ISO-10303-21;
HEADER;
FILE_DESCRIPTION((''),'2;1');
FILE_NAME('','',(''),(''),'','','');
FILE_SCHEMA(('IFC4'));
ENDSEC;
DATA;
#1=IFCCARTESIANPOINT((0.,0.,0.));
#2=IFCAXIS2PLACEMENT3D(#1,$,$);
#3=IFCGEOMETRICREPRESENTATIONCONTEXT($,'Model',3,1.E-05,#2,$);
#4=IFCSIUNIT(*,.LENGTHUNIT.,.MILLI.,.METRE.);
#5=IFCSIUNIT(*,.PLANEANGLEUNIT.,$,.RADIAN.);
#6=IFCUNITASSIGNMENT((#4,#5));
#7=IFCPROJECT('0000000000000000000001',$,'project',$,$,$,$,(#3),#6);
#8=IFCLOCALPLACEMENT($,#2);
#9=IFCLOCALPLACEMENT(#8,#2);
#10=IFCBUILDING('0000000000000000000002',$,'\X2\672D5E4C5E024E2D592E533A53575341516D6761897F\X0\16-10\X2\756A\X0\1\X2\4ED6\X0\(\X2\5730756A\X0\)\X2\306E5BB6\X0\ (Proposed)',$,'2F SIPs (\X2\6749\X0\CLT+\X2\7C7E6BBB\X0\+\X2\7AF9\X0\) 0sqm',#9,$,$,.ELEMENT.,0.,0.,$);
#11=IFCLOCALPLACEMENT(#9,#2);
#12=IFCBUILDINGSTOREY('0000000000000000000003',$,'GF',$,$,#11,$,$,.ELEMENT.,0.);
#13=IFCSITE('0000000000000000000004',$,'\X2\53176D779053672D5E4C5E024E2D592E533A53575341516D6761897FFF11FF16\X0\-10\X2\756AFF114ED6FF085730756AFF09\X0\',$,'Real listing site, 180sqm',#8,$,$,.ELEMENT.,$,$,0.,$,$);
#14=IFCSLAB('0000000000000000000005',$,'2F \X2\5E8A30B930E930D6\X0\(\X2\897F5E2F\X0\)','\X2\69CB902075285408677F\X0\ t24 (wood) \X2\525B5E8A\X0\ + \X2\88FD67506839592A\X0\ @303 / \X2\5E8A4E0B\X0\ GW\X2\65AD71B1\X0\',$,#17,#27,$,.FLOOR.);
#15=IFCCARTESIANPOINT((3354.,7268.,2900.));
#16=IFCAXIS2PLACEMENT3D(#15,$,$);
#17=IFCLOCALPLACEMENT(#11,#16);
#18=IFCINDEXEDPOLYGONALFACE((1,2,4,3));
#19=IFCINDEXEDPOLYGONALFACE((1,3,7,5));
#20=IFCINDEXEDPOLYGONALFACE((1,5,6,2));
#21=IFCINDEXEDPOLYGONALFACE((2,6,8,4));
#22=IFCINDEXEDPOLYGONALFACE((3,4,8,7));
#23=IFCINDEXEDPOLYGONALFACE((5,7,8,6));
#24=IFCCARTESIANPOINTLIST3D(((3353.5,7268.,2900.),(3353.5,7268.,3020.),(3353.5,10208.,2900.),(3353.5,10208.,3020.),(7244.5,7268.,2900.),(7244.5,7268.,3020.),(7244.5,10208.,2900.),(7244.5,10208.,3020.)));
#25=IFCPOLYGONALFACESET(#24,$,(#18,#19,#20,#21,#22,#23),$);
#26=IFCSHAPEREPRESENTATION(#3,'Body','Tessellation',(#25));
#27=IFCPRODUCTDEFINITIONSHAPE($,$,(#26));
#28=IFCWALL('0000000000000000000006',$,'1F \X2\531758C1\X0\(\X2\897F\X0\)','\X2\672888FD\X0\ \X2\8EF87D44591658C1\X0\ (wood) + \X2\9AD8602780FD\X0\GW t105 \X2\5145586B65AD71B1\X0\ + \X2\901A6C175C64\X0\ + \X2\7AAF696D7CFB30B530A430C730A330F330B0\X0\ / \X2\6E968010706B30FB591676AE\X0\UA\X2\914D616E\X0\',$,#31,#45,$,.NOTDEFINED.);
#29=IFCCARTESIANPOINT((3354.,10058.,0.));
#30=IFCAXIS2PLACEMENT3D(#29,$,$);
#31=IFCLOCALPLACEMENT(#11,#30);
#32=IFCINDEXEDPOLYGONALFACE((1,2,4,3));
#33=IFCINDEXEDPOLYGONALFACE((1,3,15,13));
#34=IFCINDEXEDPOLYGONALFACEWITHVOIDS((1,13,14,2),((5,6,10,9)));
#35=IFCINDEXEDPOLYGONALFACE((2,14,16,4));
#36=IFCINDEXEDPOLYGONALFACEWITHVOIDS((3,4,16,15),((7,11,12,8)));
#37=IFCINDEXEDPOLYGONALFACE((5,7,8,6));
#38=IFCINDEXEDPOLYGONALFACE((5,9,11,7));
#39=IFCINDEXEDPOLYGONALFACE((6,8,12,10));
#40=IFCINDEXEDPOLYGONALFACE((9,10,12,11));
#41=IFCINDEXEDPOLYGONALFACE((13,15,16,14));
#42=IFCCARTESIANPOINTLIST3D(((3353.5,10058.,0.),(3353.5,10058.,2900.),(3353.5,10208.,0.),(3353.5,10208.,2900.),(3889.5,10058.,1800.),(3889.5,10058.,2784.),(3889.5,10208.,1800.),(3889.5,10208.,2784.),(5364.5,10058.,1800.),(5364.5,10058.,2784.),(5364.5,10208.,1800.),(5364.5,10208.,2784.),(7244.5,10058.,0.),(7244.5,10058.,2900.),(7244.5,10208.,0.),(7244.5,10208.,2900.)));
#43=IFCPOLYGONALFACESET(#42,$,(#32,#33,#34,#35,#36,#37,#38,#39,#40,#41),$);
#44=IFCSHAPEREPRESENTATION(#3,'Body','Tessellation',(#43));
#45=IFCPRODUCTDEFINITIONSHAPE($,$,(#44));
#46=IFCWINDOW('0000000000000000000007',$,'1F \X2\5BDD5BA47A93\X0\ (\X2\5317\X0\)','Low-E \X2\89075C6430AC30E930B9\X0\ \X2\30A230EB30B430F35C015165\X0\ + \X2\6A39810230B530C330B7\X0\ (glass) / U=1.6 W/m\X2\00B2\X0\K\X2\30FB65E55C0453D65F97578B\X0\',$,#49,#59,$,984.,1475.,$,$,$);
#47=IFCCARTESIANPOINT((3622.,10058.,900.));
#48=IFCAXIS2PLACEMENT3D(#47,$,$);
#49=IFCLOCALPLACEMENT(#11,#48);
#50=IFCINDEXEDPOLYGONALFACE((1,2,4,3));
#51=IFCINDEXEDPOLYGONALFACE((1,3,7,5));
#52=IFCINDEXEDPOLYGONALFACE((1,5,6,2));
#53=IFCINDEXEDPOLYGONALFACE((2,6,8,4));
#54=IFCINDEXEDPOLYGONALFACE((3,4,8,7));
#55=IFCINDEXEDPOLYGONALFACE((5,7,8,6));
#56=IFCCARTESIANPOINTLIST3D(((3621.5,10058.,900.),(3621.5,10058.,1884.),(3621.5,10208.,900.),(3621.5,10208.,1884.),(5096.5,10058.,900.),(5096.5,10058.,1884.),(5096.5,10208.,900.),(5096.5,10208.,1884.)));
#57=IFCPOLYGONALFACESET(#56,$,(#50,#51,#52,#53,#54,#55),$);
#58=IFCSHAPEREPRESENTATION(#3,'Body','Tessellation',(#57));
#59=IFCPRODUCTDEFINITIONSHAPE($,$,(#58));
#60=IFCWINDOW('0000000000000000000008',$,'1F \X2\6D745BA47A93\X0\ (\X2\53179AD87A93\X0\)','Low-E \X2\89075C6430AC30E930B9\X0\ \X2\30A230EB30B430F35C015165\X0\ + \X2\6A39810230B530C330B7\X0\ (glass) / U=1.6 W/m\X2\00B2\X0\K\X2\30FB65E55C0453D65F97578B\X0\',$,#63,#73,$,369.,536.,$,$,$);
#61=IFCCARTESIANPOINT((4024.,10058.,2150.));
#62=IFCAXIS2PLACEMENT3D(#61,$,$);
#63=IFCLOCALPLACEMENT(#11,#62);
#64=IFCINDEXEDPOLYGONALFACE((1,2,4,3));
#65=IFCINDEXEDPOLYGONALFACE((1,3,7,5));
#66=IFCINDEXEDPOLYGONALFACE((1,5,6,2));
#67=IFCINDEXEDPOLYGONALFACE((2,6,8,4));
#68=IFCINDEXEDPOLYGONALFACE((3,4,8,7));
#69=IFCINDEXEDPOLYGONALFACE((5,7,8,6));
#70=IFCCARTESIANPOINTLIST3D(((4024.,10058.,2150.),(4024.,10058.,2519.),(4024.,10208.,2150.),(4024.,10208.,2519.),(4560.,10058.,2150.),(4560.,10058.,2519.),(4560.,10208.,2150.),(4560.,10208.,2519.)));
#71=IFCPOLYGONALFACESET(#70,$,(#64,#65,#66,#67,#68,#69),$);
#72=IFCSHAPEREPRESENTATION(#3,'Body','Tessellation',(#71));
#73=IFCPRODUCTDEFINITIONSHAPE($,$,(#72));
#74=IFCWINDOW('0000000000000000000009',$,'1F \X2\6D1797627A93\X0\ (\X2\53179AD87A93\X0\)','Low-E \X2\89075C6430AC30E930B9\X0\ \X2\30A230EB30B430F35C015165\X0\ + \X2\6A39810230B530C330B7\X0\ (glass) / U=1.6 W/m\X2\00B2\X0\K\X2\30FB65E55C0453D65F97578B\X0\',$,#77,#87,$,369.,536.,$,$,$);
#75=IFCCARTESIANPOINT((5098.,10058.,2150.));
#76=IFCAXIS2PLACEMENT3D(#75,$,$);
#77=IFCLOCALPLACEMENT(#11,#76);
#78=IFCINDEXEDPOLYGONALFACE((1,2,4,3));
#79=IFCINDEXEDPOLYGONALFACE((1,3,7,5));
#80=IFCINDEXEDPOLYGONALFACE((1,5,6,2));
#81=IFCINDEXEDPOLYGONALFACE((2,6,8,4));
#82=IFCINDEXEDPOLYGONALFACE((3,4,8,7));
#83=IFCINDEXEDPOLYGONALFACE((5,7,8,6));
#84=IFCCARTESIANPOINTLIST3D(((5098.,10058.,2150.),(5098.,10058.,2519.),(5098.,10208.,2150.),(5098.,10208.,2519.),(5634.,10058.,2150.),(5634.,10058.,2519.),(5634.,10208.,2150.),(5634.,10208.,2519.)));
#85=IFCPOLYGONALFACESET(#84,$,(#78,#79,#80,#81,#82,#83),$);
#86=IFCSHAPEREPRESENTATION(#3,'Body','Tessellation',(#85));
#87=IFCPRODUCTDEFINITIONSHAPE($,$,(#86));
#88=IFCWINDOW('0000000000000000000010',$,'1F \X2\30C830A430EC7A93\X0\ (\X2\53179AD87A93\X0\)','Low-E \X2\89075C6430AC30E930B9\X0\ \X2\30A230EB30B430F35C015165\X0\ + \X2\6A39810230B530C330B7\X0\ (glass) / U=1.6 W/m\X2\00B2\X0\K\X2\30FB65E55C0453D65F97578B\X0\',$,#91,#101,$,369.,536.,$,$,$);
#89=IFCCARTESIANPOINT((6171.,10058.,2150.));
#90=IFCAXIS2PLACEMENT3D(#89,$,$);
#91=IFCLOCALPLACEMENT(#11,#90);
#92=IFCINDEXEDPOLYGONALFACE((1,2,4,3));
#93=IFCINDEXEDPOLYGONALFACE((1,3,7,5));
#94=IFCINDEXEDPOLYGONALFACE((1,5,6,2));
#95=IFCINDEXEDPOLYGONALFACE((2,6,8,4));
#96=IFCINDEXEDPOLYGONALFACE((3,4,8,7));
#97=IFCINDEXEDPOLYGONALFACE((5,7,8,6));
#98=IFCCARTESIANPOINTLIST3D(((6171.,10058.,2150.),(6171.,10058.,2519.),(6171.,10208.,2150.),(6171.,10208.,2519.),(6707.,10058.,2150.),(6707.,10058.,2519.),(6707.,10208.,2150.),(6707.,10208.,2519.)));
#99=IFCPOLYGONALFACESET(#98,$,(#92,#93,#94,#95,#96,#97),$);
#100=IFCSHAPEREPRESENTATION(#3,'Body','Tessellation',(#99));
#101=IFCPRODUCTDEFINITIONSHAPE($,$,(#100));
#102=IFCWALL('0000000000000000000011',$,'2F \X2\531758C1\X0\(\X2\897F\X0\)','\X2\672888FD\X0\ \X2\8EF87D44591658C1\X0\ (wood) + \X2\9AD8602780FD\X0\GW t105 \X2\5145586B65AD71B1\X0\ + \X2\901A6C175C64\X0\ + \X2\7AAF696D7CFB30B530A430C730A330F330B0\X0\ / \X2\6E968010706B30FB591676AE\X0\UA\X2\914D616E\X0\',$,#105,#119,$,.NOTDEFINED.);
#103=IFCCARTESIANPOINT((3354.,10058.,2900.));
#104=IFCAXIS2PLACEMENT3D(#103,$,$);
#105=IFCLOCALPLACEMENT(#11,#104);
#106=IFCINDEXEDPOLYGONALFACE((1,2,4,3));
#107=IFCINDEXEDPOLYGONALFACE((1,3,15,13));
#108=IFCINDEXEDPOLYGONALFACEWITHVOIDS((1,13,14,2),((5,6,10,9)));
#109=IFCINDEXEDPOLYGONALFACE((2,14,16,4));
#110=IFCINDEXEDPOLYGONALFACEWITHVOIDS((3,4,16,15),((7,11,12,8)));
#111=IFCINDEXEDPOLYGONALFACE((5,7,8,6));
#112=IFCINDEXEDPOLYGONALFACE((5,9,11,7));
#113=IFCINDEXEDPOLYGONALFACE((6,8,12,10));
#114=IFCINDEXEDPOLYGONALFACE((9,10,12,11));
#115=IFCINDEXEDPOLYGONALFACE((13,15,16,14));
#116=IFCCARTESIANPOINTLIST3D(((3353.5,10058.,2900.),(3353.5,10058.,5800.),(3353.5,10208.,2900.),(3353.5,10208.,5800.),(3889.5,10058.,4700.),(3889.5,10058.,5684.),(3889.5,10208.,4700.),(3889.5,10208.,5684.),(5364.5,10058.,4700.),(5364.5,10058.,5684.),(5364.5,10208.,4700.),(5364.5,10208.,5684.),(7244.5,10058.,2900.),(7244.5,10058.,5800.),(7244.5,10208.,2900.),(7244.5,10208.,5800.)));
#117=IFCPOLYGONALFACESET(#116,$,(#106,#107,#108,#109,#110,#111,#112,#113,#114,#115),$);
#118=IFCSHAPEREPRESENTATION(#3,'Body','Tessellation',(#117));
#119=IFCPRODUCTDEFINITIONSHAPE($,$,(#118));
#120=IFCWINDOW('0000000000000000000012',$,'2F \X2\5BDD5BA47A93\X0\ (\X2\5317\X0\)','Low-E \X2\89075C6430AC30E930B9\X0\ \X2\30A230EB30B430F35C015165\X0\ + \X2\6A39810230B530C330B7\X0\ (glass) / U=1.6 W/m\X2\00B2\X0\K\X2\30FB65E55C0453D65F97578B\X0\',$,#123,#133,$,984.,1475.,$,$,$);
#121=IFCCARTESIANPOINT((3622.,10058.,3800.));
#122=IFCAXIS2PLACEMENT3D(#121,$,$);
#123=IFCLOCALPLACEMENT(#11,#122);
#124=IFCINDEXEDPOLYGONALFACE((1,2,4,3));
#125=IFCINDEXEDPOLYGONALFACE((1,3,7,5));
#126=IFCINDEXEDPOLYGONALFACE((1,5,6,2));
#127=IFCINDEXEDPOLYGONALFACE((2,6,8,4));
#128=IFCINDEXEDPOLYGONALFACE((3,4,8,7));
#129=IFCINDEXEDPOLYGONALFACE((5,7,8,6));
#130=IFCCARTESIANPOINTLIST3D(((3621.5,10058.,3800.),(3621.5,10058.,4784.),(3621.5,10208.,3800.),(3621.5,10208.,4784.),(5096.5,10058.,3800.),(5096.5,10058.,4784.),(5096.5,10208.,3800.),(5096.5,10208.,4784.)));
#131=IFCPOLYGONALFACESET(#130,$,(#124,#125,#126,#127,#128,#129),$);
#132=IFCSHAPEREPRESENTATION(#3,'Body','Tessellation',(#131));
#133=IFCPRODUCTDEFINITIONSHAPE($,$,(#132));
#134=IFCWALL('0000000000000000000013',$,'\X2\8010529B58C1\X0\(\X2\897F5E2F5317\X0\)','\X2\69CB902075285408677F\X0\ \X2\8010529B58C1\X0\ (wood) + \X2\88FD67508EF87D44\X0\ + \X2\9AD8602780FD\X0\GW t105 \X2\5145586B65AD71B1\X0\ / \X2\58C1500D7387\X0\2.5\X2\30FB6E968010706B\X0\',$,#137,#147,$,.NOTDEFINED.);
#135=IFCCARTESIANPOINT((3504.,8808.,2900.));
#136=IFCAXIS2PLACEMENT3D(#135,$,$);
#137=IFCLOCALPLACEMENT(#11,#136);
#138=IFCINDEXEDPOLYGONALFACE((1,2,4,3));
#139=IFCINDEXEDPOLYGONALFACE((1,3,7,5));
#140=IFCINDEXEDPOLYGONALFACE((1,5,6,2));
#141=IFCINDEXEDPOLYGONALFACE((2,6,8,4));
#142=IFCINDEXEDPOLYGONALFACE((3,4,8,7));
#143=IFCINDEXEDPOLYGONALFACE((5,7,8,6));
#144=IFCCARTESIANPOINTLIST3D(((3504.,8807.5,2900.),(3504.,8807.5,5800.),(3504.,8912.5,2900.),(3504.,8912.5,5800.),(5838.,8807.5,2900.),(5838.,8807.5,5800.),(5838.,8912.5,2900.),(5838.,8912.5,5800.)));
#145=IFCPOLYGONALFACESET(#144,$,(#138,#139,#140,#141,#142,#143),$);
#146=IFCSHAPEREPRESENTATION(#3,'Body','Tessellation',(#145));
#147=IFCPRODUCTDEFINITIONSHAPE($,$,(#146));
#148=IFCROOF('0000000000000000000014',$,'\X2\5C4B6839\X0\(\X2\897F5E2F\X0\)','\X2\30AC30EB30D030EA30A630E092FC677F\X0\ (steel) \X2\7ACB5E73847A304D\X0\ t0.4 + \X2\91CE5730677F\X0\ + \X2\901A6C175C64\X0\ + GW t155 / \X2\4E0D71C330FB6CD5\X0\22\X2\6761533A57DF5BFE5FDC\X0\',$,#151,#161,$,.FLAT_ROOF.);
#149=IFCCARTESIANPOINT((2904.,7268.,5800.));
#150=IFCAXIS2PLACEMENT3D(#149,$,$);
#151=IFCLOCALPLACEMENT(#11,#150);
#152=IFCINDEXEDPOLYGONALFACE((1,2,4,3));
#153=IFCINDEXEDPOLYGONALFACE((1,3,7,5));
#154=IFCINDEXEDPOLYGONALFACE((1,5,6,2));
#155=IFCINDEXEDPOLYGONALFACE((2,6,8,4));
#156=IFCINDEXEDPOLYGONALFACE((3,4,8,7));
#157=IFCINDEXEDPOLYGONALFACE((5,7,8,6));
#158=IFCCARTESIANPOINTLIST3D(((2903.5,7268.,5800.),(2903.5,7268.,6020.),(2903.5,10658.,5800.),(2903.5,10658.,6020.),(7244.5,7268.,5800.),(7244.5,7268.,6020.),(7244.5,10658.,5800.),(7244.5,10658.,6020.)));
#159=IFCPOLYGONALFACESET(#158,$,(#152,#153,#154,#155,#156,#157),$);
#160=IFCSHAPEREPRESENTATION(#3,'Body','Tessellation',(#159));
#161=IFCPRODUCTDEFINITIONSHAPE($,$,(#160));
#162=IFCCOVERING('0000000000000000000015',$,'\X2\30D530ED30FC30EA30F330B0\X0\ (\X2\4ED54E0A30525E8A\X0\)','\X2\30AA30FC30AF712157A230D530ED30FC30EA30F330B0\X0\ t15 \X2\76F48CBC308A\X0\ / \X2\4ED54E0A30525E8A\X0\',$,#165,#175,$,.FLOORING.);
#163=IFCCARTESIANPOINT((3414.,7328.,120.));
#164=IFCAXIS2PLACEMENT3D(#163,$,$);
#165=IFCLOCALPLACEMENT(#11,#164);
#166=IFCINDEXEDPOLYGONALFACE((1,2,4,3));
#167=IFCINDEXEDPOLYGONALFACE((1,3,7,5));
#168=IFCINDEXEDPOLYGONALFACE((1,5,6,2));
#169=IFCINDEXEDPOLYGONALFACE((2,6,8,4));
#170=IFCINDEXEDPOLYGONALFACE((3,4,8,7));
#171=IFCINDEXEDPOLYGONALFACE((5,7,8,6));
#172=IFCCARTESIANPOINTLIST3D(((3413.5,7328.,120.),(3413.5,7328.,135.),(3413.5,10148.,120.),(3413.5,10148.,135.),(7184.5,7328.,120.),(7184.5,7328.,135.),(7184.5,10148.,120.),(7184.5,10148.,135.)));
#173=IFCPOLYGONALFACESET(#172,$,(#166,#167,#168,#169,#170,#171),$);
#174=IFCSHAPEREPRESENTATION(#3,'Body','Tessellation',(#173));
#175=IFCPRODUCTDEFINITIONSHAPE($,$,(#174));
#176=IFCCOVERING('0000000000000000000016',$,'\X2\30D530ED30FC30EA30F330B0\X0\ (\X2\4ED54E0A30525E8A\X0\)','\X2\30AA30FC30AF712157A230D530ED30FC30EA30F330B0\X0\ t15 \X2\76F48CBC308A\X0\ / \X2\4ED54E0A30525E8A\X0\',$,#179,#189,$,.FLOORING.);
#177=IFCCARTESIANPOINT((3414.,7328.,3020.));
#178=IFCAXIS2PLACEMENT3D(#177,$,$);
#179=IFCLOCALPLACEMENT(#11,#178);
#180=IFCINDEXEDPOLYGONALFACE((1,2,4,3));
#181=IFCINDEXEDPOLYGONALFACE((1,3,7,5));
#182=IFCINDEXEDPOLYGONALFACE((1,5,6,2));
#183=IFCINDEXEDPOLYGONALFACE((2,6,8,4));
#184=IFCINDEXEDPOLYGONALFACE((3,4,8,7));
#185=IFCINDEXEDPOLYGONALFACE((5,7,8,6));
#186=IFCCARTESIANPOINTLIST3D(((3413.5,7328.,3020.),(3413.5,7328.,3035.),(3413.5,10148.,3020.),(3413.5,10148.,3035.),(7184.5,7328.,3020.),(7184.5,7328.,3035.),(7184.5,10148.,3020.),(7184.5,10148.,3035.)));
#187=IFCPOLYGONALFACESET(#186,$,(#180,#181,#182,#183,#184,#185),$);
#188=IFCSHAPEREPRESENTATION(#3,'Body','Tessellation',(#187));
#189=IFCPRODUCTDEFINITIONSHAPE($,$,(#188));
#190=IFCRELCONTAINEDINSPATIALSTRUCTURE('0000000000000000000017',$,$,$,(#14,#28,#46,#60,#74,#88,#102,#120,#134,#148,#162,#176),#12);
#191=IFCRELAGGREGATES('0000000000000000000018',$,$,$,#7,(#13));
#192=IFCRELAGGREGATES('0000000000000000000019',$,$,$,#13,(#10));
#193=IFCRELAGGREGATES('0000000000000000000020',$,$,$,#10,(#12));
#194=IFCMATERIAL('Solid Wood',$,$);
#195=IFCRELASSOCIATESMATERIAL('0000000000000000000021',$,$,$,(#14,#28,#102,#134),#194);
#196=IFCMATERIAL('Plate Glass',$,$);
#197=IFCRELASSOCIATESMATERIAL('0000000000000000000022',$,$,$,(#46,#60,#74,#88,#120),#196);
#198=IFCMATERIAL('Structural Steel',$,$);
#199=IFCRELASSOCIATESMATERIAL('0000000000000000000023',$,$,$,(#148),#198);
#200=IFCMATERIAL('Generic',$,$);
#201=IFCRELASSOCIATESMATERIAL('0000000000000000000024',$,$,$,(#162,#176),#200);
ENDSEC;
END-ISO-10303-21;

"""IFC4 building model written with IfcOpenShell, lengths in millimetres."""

from ifc_helpers import new_model, si_unit, frame, frame_2d, origin, place, context, project, spatial, rectangle, extrude, material, element, fill, save


model = new_model("IFC4")

# Units and contexts
model_context = context("Model", 3, precision=1e-05, world=origin())
ifc_project = project(units=[si_unit("LENGTHUNIT", "METRE", prefix="MILLI"), si_unit("PLANEANGLEUNIT", "RADIAN")], contexts=[model_context])

# Site, building, storey
site_placement = place(None, origin())
site = spatial("IfcSite", under=ifc_project, at=site_placement, Name="北海道札幌市中央区南十六条西１６-10番１他（地番）", ObjectType="Real listing site, 180sqm", CompositionType="ELEMENT", RefElevation=0.0)
building_placement = place(site_placement, origin())
building = spatial("IfcBuilding", under=site, at=building_placement, Name="札幌市中央区南十六条西16-10番1他(地番)の家 (Proposed)", ObjectType="2F SIPs (杉CLT+籾殻+竹) 0sqm", CompositionType="ELEMENT", ElevationOfRefHeight=0.0, ElevationOfTerrain=0.0)
storey_placement = place(building_placement, origin())
storey = spatial("IfcBuildingStorey", under=building, at=storey_placement, Name="GF", CompositionType="ELEMENT", Elevation=0.0)

# Slab
ifc_material_1 = material(Name="Solid Wood")
slab_1_placement = place(storey_placement, frame((3354.0, 7268.0, 2900.0)))
element("IfcSlab", 1, at=slab_1_placement, inside=storey, material=ifc_material_1, Name="2F 床スラブ(西帯)", Description="構造用合板 t24 (wood) 剛床 + 製材根太 @303 / 床下 GW断熱", PredefinedType="FLOOR", context=model_context, shape_type="SweptSolid", body=[
    extrude(rectangle(XDim=3891.0, YDim=2940.0, at=frame_2d((1945.0, 1470.0))), frame((3354.0, 7268.0, 2900.0)), (0.0, 0.0, 1.0), 120.0),
])

# Wall, openings, windows
wall_1_placement = place(storey_placement, frame((3354.0, 10058.0, 0.0)))
wall_1 = element("IfcWall", 2, at=wall_1_placement, inside=storey, material=ifc_material_1, Name="1F 北壁(西)", Description="木製 軸組外壁 (wood) + 高性能GW t105 充填断熱 + 通気層 + 窯業系サイディング / 準耐火・外皮UA配慮", PredefinedType="NOTDEFINED", context=model_context, shape_type="SweptSolid", body=[
    extrude(rectangle(XDim=3891.0, YDim=150.0, at=frame_2d((1945.0, 75.0))), frame((3354.0, 10058.0, 0.0)), (0.0, 0.0, 1.0), 2900.0),
])
opening_1_placement = place(storey_placement, frame((3622.0, 10058.0, 900.0)))
opening_1 = element("IfcOpeningElement", 3, at=opening_1_placement, cuts=wall_1, PredefinedType="NOTDEFINED", context=model_context, shape_type="SweptSolid", body=[
    extrude(rectangle(XDim=1475.0, YDim=150.0, at=frame_2d((737.0, 75.0))), frame((3622.0, 10058.0, 900.0)), (0.0, 0.0, 1.0), 984.0),
])
opening_2_placement = place(storey_placement, frame((4024.0, 10058.0, 2150.0)))
opening_2 = element("IfcOpeningElement", 4, at=opening_2_placement, cuts=wall_1, PredefinedType="NOTDEFINED", context=model_context, shape_type="SweptSolid", body=[
    extrude(rectangle(XDim=536.0, YDim=150.0, at=frame_2d((268.0, 75.0))), frame((4024.0, 10058.0, 2150.0)), (0.0, 0.0, 1.0), 369.0),
])
opening_3_placement = place(storey_placement, frame((5098.0, 10058.0, 2150.0)))
opening_3 = element("IfcOpeningElement", 5, at=opening_3_placement, cuts=wall_1, PredefinedType="NOTDEFINED", context=model_context, shape_type="SweptSolid", body=[
    extrude(rectangle(XDim=536.0, YDim=150.0, at=frame_2d((268.0, 75.0))), frame((5098.0, 10058.0, 2150.0)), (0.0, 0.0, 1.0), 369.0),
])
opening_4_placement = place(storey_placement, frame((6171.0, 10058.0, 2150.0)))
opening_4 = element("IfcOpeningElement", 6, at=opening_4_placement, cuts=wall_1, PredefinedType="NOTDEFINED", context=model_context, shape_type="SweptSolid", body=[
    extrude(rectangle(XDim=536.0, YDim=150.0, at=frame_2d((268.0, 75.0))), frame((6171.0, 10058.0, 2150.0)), (0.0, 0.0, 1.0), 369.0),
])
ifc_material_2 = material(Name="Plate Glass")
window_1_placement = place(storey_placement, frame((3622.0, 10058.0, 900.0)))
window_1 = element("IfcWindow", 7, at=window_1_placement, inside=storey, material=ifc_material_2, Name="1F 寝室窓 (北)", Description="Low-E 複層ガラス アルゴン封入 + 樹脂サッシ (glass) / U=1.6 W/m²K・日射取得型", OverallHeight=984.0, OverallWidth=1475.0, context=model_context, shape_type="SweptSolid", body=[
    extrude(rectangle(XDim=1475.0, YDim=150.0, at=frame_2d((737.0, 75.0))), frame((3622.0, 10058.0, 900.0)), (0.0, 0.0, 1.0), 984.0),
])
fill(opening_1, window_1)
window_2_placement = place(storey_placement, frame((4024.0, 10058.0, 2150.0)))
window_2 = element("IfcWindow", 8, at=window_2_placement, inside=storey, material=ifc_material_2, Name="1F 浴室窓 (北高窓)", Description="Low-E 複層ガラス アルゴン封入 + 樹脂サッシ (glass) / U=1.6 W/m²K・日射取得型", OverallHeight=369.0, OverallWidth=536.0, context=model_context, shape_type="SweptSolid", body=[
    extrude(rectangle(XDim=536.0, YDim=150.0, at=frame_2d((268.0, 75.0))), frame((4024.0, 10058.0, 2150.0)), (0.0, 0.0, 1.0), 369.0),
])
fill(opening_2, window_2)
window_3_placement = place(storey_placement, frame((5098.0, 10058.0, 2150.0)))
window_3 = element("IfcWindow", 9, at=window_3_placement, inside=storey, material=ifc_material_2, Name="1F 洗面窓 (北高窓)", Description="Low-E 複層ガラス アルゴン封入 + 樹脂サッシ (glass) / U=1.6 W/m²K・日射取得型", OverallHeight=369.0, OverallWidth=536.0, context=model_context, shape_type="SweptSolid", body=[
    extrude(rectangle(XDim=536.0, YDim=150.0, at=frame_2d((268.0, 75.0))), frame((5098.0, 10058.0, 2150.0)), (0.0, 0.0, 1.0), 369.0),
])
fill(opening_3, window_3)
window_4_placement = place(storey_placement, frame((6171.0, 10058.0, 2150.0)))
window_4 = element("IfcWindow", 10, at=window_4_placement, inside=storey, material=ifc_material_2, Name="1F トイレ窓 (北高窓)", Description="Low-E 複層ガラス アルゴン封入 + 樹脂サッシ (glass) / U=1.6 W/m²K・日射取得型", OverallHeight=369.0, OverallWidth=536.0, context=model_context, shape_type="SweptSolid", body=[
    extrude(rectangle(XDim=536.0, YDim=150.0, at=frame_2d((268.0, 75.0))), frame((6171.0, 10058.0, 2150.0)), (0.0, 0.0, 1.0), 369.0),
])
fill(opening_4, window_4)

# Wall, opening, window
wall_2_placement = place(storey_placement, frame((3354.0, 10058.0, 2900.0)))
wall_2 = element("IfcWall", 11, at=wall_2_placement, inside=storey, material=ifc_material_1, Name="2F 北壁(西)", Description="木製 軸組外壁 (wood) + 高性能GW t105 充填断熱 + 通気層 + 窯業系サイディング / 準耐火・外皮UA配慮", PredefinedType="NOTDEFINED", context=model_context, shape_type="SweptSolid", body=[
    extrude(rectangle(XDim=3891.0, YDim=150.0, at=frame_2d((1945.0, 75.0))), frame((3354.0, 10058.0, 2900.0)), (0.0, 0.0, 1.0), 2900.0),
])
opening_5_placement = place(storey_placement, frame((3622.0, 10058.0, 3800.0)))
opening_5 = element("IfcOpeningElement", 12, at=opening_5_placement, cuts=wall_2, PredefinedType="NOTDEFINED", context=model_context, shape_type="SweptSolid", body=[
    extrude(rectangle(XDim=1475.0, YDim=150.0, at=frame_2d((737.0, 75.0))), frame((3622.0, 10058.0, 3800.0)), (0.0, 0.0, 1.0), 984.0),
])
window_5_placement = place(storey_placement, frame((3622.0, 10058.0, 3800.0)))
window_5 = element("IfcWindow", 13, at=window_5_placement, inside=storey, material=ifc_material_2, Name="2F 寝室窓 (北)", Description="Low-E 複層ガラス アルゴン封入 + 樹脂サッシ (glass) / U=1.6 W/m²K・日射取得型", OverallHeight=984.0, OverallWidth=1475.0, context=model_context, shape_type="SweptSolid", body=[
    extrude(rectangle(XDim=1475.0, YDim=150.0, at=frame_2d((737.0, 75.0))), frame((3622.0, 10058.0, 3800.0)), (0.0, 0.0, 1.0), 984.0),
])
fill(opening_5, window_5)

# Wall
wall_3_placement = place(storey_placement, frame((3504.0, 8808.0, 2900.0)))
element("IfcWall", 14, at=wall_3_placement, inside=storey, material=ifc_material_1, Name="耐力壁(西帯北)", Description="構造用合板 耐力壁 (wood) + 製材軸組 + 高性能GW t105 充填断熱 / 壁倍率2.5・準耐火", PredefinedType="NOTDEFINED", context=model_context, shape_type="SweptSolid", body=[
    extrude(rectangle(XDim=2334.0, YDim=105.0, at=frame_2d((1167.0, 52.0))), frame((3504.0, 8808.0, 2900.0)), (0.0, 0.0, 1.0), 2900.0),
])

# Roof
ifc_material_3 = material(Name="Structural Steel")
for number, where, name in (
    (15, (2904.0, 7268.0, 5800.0), "屋根(西帯)"),
):
    element("IfcRoof", number, at=place(storey_placement, frame(where)), inside=storey, material=ifc_material_3, Name=name, Description="ガルバリウム鋼板 (steel) 立平葺き t0.4 + 野地板 + 通気層 + GW t155 / 不燃・法22条区域対応", PredefinedType="FLAT_ROOF", context=model_context, shape_type="SweptSolid", body=[
        extrude(rectangle(XDim=4341.0, YDim=3390.0, at=frame_2d((2170.0, 1695.0))), frame((2904.0, 7268.0, 5800.0)), (0.0, 0.0, 1.0), 220.0),
    ])

# Coverings
ifc_material_4 = material(Name="Generic")
covering_1_placement = place(storey_placement, frame((3414.0, 7328.0, 120.0)))
element("IfcCovering", 16, at=covering_1_placement, inside=storey, material=ifc_material_4, Name="フローリング (仕上げ床)", Description="オーク無垢フローリング t15 直貼り / 仕上げ床", PredefinedType="FLOORING", context=model_context, shape_type="SweptSolid", body=[
    extrude(rectangle(XDim=3771.0, YDim=2820.0, at=frame_2d((1885.0, 1410.0))), frame((3414.0, 7328.0, 120.0)), (0.0, 0.0, 1.0), 15.0),
])
covering_2_placement = place(storey_placement, frame((3414.0, 7328.0, 3020.0)))
element("IfcCovering", 17, at=covering_2_placement, inside=storey, material=ifc_material_4, Name="フローリング (仕上げ床)", Description="オーク無垢フローリング t15 直貼り / 仕上げ床", PredefinedType="FLOORING", context=model_context, shape_type="SweptSolid", body=[
    extrude(rectangle(XDim=3771.0, YDim=2820.0, at=frame_2d((1885.0, 1410.0))), frame((3414.0, 7328.0, 3020.0)), (0.0, 0.0, 1.0), 15.0),
])

save(model, "model.ifc")
